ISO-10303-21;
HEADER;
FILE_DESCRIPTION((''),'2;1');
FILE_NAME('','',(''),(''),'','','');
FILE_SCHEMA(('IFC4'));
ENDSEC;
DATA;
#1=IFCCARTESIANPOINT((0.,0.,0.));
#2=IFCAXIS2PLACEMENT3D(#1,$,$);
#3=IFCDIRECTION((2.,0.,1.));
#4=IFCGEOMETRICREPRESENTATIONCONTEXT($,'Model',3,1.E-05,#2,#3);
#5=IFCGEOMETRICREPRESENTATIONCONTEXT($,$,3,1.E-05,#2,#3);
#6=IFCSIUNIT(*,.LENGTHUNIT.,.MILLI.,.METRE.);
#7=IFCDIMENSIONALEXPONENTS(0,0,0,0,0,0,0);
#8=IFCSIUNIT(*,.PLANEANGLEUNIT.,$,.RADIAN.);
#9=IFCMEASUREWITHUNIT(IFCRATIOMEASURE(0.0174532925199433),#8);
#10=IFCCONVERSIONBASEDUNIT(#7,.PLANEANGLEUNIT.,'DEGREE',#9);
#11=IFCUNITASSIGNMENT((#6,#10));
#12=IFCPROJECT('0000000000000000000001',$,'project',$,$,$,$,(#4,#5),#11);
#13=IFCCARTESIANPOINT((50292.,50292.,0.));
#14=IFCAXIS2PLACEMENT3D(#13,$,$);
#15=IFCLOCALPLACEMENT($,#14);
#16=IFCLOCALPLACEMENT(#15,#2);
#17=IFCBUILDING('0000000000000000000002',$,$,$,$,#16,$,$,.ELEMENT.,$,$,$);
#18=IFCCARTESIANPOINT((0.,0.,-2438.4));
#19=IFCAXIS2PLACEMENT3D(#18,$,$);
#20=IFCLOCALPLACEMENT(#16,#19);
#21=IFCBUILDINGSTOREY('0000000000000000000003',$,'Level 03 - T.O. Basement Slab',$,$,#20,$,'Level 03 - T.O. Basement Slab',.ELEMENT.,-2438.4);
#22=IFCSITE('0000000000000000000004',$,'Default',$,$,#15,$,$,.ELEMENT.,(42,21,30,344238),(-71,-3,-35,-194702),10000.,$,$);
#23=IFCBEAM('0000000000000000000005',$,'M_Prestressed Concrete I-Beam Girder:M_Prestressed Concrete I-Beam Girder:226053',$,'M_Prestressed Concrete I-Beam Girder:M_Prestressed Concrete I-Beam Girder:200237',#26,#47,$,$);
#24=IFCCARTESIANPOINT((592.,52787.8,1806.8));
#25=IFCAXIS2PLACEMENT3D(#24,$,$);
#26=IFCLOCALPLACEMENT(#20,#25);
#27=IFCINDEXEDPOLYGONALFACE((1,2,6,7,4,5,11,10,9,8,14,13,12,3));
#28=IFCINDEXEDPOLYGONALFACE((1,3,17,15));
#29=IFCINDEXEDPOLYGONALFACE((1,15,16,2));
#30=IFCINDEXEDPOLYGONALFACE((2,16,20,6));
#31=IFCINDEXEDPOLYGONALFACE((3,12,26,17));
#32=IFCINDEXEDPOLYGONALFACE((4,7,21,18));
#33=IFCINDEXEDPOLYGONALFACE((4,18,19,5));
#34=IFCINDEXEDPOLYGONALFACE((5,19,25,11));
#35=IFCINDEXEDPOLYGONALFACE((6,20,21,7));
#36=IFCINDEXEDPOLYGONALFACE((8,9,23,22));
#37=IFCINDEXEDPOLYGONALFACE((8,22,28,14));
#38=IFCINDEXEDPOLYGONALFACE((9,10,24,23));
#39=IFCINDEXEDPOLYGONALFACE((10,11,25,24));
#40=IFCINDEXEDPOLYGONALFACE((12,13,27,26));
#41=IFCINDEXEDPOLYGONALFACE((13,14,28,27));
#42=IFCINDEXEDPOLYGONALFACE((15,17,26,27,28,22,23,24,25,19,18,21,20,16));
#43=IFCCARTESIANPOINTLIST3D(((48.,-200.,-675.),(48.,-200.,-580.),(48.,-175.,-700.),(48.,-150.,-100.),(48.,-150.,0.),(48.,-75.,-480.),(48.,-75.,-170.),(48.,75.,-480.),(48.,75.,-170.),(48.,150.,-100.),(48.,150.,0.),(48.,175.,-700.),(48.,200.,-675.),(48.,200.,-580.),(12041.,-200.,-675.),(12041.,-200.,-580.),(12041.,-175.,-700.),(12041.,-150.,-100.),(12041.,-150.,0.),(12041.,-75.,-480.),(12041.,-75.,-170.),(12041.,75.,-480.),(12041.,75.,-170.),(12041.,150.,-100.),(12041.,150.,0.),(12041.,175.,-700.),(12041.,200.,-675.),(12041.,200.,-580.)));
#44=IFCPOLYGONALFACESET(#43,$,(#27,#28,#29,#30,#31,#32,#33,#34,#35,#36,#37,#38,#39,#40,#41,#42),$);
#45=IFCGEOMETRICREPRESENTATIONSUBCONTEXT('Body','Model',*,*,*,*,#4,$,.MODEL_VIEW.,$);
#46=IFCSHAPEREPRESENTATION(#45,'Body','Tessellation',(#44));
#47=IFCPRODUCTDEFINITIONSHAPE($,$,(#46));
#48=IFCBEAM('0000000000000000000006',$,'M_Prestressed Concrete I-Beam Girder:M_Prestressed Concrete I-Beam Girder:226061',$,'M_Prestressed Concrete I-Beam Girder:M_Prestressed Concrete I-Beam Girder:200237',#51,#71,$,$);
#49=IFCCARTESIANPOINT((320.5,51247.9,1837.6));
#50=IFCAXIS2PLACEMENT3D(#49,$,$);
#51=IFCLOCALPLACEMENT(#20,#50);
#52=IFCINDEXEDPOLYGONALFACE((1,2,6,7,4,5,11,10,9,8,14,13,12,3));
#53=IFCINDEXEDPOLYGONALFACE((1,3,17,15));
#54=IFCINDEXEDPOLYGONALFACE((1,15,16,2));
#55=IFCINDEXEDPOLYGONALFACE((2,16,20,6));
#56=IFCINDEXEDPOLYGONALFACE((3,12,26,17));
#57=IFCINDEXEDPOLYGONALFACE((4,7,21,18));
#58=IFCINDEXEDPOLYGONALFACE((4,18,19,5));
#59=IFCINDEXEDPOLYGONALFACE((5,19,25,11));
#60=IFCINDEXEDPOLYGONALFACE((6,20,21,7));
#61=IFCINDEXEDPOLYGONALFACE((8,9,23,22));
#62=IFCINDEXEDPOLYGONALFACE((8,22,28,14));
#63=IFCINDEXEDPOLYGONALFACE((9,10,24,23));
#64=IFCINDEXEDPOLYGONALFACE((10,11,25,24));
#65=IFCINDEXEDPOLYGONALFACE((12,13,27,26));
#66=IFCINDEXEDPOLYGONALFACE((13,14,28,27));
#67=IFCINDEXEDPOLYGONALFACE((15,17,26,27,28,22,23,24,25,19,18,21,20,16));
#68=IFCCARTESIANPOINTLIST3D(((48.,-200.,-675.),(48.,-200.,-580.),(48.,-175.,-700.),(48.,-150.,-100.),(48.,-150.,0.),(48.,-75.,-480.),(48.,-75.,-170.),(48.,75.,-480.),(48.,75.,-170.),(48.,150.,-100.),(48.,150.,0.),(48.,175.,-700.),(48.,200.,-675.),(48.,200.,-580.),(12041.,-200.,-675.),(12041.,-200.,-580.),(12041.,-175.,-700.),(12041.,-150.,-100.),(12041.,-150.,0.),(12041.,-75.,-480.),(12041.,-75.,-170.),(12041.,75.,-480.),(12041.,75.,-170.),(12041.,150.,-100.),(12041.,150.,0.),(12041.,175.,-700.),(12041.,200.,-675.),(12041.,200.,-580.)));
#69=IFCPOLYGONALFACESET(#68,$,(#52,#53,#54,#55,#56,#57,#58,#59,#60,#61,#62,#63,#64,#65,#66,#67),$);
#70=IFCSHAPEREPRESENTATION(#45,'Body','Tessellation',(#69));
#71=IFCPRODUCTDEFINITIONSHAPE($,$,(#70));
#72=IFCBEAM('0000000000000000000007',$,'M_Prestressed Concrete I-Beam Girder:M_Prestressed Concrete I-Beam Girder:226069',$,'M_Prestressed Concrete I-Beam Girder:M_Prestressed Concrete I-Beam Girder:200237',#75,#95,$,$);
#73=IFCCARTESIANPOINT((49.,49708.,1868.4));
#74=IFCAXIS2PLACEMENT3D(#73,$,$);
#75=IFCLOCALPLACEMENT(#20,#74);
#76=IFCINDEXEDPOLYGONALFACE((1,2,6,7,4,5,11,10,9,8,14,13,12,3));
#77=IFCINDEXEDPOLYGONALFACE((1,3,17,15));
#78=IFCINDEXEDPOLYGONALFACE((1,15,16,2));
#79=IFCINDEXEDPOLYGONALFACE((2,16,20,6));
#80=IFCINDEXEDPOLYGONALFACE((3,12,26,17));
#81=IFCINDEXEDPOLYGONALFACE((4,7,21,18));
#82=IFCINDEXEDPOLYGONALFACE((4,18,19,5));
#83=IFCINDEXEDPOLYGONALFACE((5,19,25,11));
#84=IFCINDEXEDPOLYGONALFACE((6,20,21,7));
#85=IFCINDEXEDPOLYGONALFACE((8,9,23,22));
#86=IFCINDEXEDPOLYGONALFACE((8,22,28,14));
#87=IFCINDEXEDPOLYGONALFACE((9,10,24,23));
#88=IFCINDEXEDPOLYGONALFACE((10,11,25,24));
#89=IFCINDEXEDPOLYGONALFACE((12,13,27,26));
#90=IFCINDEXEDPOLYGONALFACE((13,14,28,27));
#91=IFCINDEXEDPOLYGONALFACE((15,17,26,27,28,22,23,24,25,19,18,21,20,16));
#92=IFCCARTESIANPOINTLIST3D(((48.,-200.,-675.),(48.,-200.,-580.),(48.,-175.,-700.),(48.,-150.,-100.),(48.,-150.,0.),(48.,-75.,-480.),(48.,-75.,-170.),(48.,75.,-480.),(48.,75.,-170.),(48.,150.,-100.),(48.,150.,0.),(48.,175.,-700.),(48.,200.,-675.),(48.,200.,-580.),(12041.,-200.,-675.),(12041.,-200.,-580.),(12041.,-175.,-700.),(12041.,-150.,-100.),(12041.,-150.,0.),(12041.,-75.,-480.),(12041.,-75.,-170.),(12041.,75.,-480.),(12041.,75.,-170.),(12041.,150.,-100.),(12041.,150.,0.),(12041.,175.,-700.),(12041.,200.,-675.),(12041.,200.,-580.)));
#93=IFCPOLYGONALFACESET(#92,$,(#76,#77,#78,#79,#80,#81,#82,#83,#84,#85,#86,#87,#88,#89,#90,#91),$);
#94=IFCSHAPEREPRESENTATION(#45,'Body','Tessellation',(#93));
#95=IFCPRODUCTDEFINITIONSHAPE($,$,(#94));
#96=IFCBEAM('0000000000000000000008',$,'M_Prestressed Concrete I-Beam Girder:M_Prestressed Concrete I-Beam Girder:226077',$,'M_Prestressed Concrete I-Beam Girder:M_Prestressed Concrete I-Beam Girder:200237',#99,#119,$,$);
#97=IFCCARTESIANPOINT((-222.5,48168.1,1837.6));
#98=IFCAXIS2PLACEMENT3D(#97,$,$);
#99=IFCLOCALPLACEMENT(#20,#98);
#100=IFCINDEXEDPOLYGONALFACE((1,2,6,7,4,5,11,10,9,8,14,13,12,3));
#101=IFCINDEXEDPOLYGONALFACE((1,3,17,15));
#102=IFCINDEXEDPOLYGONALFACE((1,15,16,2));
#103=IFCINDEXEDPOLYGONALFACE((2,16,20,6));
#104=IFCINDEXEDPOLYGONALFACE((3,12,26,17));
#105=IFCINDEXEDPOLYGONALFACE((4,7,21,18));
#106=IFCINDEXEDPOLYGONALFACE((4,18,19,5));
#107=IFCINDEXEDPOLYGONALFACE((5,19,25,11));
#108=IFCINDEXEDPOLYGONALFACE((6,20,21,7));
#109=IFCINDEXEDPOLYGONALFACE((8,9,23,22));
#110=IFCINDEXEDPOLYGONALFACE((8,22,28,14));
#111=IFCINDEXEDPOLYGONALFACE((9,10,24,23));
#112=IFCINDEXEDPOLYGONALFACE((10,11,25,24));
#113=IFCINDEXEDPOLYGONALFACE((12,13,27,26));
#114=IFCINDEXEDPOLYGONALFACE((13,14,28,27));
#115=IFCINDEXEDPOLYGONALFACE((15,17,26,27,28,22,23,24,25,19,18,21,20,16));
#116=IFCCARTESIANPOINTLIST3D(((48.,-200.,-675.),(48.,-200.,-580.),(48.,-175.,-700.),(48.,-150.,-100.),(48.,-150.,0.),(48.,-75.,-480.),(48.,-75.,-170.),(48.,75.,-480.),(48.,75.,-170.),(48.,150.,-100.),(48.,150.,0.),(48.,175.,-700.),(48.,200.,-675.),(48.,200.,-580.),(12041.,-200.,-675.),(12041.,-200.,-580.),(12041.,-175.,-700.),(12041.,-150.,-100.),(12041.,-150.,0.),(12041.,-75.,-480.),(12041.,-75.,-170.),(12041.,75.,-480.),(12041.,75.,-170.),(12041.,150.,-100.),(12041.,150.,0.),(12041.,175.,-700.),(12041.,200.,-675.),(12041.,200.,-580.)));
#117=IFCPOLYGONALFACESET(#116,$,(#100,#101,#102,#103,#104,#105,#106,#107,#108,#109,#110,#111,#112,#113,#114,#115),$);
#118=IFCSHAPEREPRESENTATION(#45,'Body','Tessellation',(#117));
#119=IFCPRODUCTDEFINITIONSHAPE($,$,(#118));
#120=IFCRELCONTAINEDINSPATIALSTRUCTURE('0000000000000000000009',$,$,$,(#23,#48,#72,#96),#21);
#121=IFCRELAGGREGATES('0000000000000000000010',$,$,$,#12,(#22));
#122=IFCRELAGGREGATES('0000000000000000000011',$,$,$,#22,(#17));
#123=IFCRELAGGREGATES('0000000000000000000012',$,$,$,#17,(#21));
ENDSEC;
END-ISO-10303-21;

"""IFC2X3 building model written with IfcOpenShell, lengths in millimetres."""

from ifc_helpers import new_model, entity, si_unit, converted_unit, direction, frame, origin, place, context, subcontext, project, spatial, polyline, outline, extrude, element, save


model = new_model("IFC2X3")

# Units and contexts
model_context = context("Model", 3, precision=1e-05, world=origin(), true_north=direction((2.0, 0.0, 1.0)))
context_of_model = context(None, 3, precision=1e-05, world=origin(), true_north=direction((2.0, 0.0, 1.0)))
body_context = subcontext(model_context, "Body", "Model", "MODEL_VIEW")
ifc_project = project(units=[si_unit("LENGTHUNIT", "METRE", prefix="MILLI"), converted_unit("PLANEANGLEUNIT", "DEGREE", entity("IfcRatioMeasure", 0.0174532925199433), si_unit("PLANEANGLEUNIT", "RADIAN"), dimensions=[0, 0, 0, 0, 0, 0, 0])], contexts=[model_context, context_of_model])

# Site, building, storey
site_placement = place(None, frame((50292.0, 50292.0, 0.0)))
site = spatial("IfcSite", under=ifc_project, at=site_placement, Name="Default", CompositionType="ELEMENT", RefLatitude=(42, 21, 30, 344238), RefLongitude=(-71, -3, -35, -194702), RefElevation=10000.0)
building_placement = place(site_placement, origin())
building = spatial("IfcBuilding", under=site, at=building_placement, CompositionType="ELEMENT")
storey_placement = place(building_placement, frame((0.0, 0.0, -2438.4)))
storey = spatial("IfcBuildingStorey", under=building, at=storey_placement, Name="Level 03 - T.O. Basement Slab", LongName="Level 03 - T.O. Basement Slab", CompositionType="ELEMENT", Elevation=-2438.4)

# Beams
beam_1_placement = place(storey_placement, frame((592.0, 52787.8, 1806.8)))
element("IfcBeam", 1, at=beam_1_placement, inside=storey, Name="M_Prestressed Concrete I-Beam Girder:M_Prestressed Concrete I-Beam Girder:226053", ObjectType="M_Prestressed Concrete I-Beam Girder:M_Prestressed Concrete I-Beam Girder:200237", context=body_context, shape_type="SweptSolid", body=[
    extrude(outline(polyline([(193.6, -200.0), (288.6, -200.0), (313.6, -175.0), (313.6, 175.0), (288.6, 200.0), (193.6, 200.0), (93.6, 75.0), (-216.4, 75.0), (-286.4, 150.0), (-386.4, 150.0), (-386.4, -150.0), (-286.4, -150.0), (-216.4, -75.0), (93.6, -75.0), (193.6, -200.0)])), frame((48.0, 0.0, -386.4), z_axis=(1.0, 0.0, 0.0), x_axis=(0.0, 0.0, -1.0)), (0.0, 0.0, 1.0), 11993.0),
])
beam_2_placement = place(storey_placement, frame((320.5, 51247.9, 1837.6)))
element("IfcBeam", 2, at=beam_2_placement, inside=storey, Name="M_Prestressed Concrete I-Beam Girder:M_Prestressed Concrete I-Beam Girder:226061", ObjectType="M_Prestressed Concrete I-Beam Girder:M_Prestressed Concrete I-Beam Girder:200237", context=body_context, shape_type="SweptSolid", body=[
    extrude(outline(polyline([(193.6, -200.0), (288.6, -200.0), (313.6, -175.0), (313.6, 175.0), (288.6, 200.0), (193.6, 200.0), (93.6, 75.0), (-216.4, 75.0), (-286.4, 150.0), (-386.4, 150.0), (-386.4, -150.0), (-286.4, -150.0), (-216.4, -75.0), (93.6, -75.0), (193.6, -200.0)])), frame((48.0, 0.0, -386.4), z_axis=(1.0, 0.0, 0.0), x_axis=(0.0, 0.0, -1.0)), (0.0, 0.0, 1.0), 11993.0),
])
beam_3_placement = place(storey_placement, frame((49.0, 49708.0, 1868.4)))
element("IfcBeam", 3, at=beam_3_placement, inside=storey, Name="M_Prestressed Concrete I-Beam Girder:M_Prestressed Concrete I-Beam Girder:226069", ObjectType="M_Prestressed Concrete I-Beam Girder:M_Prestressed Concrete I-Beam Girder:200237", context=body_context, shape_type="SweptSolid", body=[
    extrude(outline(polyline([(193.6, -200.0), (288.6, -200.0), (313.6, -175.0), (313.6, 175.0), (288.6, 200.0), (193.6, 200.0), (93.6, 75.0), (-216.4, 75.0), (-286.4, 150.0), (-386.4, 150.0), (-386.4, -150.0), (-286.4, -150.0), (-216.4, -75.0), (93.6, -75.0), (193.6, -200.0)])), frame((48.0, 0.0, -386.4), z_axis=(1.0, 0.0, 0.0), x_axis=(0.0, 0.0, -1.0)), (0.0, 0.0, 1.0), 11993.0),
])
beam_4_placement = place(storey_placement, frame((-222.5, 48168.1, 1837.6)))
element("IfcBeam", 4, at=beam_4_placement, inside=storey, Name="M_Prestressed Concrete I-Beam Girder:M_Prestressed Concrete I-Beam Girder:226077", ObjectType="M_Prestressed Concrete I-Beam Girder:M_Prestressed Concrete I-Beam Girder:200237", context=body_context, shape_type="SweptSolid", body=[
    extrude(outline(polyline([(193.6, -200.0), (288.6, -200.0), (313.6, -175.0), (313.6, 175.0), (288.6, 200.0), (193.6, 200.0), (93.6, 75.0), (-216.4, 75.0), (-286.4, 150.0), (-386.4, 150.0), (-386.4, -150.0), (-286.4, -150.0), (-216.4, -75.0), (93.6, -75.0), (193.6, -200.0)])), frame((48.0, 0.0, -386.4), z_axis=(1.0, 0.0, 0.0), x_axis=(0.0, 0.0, -1.0)), (0.0, 0.0, 1.0), 11993.0),
])

save(model, "model.ifc")
